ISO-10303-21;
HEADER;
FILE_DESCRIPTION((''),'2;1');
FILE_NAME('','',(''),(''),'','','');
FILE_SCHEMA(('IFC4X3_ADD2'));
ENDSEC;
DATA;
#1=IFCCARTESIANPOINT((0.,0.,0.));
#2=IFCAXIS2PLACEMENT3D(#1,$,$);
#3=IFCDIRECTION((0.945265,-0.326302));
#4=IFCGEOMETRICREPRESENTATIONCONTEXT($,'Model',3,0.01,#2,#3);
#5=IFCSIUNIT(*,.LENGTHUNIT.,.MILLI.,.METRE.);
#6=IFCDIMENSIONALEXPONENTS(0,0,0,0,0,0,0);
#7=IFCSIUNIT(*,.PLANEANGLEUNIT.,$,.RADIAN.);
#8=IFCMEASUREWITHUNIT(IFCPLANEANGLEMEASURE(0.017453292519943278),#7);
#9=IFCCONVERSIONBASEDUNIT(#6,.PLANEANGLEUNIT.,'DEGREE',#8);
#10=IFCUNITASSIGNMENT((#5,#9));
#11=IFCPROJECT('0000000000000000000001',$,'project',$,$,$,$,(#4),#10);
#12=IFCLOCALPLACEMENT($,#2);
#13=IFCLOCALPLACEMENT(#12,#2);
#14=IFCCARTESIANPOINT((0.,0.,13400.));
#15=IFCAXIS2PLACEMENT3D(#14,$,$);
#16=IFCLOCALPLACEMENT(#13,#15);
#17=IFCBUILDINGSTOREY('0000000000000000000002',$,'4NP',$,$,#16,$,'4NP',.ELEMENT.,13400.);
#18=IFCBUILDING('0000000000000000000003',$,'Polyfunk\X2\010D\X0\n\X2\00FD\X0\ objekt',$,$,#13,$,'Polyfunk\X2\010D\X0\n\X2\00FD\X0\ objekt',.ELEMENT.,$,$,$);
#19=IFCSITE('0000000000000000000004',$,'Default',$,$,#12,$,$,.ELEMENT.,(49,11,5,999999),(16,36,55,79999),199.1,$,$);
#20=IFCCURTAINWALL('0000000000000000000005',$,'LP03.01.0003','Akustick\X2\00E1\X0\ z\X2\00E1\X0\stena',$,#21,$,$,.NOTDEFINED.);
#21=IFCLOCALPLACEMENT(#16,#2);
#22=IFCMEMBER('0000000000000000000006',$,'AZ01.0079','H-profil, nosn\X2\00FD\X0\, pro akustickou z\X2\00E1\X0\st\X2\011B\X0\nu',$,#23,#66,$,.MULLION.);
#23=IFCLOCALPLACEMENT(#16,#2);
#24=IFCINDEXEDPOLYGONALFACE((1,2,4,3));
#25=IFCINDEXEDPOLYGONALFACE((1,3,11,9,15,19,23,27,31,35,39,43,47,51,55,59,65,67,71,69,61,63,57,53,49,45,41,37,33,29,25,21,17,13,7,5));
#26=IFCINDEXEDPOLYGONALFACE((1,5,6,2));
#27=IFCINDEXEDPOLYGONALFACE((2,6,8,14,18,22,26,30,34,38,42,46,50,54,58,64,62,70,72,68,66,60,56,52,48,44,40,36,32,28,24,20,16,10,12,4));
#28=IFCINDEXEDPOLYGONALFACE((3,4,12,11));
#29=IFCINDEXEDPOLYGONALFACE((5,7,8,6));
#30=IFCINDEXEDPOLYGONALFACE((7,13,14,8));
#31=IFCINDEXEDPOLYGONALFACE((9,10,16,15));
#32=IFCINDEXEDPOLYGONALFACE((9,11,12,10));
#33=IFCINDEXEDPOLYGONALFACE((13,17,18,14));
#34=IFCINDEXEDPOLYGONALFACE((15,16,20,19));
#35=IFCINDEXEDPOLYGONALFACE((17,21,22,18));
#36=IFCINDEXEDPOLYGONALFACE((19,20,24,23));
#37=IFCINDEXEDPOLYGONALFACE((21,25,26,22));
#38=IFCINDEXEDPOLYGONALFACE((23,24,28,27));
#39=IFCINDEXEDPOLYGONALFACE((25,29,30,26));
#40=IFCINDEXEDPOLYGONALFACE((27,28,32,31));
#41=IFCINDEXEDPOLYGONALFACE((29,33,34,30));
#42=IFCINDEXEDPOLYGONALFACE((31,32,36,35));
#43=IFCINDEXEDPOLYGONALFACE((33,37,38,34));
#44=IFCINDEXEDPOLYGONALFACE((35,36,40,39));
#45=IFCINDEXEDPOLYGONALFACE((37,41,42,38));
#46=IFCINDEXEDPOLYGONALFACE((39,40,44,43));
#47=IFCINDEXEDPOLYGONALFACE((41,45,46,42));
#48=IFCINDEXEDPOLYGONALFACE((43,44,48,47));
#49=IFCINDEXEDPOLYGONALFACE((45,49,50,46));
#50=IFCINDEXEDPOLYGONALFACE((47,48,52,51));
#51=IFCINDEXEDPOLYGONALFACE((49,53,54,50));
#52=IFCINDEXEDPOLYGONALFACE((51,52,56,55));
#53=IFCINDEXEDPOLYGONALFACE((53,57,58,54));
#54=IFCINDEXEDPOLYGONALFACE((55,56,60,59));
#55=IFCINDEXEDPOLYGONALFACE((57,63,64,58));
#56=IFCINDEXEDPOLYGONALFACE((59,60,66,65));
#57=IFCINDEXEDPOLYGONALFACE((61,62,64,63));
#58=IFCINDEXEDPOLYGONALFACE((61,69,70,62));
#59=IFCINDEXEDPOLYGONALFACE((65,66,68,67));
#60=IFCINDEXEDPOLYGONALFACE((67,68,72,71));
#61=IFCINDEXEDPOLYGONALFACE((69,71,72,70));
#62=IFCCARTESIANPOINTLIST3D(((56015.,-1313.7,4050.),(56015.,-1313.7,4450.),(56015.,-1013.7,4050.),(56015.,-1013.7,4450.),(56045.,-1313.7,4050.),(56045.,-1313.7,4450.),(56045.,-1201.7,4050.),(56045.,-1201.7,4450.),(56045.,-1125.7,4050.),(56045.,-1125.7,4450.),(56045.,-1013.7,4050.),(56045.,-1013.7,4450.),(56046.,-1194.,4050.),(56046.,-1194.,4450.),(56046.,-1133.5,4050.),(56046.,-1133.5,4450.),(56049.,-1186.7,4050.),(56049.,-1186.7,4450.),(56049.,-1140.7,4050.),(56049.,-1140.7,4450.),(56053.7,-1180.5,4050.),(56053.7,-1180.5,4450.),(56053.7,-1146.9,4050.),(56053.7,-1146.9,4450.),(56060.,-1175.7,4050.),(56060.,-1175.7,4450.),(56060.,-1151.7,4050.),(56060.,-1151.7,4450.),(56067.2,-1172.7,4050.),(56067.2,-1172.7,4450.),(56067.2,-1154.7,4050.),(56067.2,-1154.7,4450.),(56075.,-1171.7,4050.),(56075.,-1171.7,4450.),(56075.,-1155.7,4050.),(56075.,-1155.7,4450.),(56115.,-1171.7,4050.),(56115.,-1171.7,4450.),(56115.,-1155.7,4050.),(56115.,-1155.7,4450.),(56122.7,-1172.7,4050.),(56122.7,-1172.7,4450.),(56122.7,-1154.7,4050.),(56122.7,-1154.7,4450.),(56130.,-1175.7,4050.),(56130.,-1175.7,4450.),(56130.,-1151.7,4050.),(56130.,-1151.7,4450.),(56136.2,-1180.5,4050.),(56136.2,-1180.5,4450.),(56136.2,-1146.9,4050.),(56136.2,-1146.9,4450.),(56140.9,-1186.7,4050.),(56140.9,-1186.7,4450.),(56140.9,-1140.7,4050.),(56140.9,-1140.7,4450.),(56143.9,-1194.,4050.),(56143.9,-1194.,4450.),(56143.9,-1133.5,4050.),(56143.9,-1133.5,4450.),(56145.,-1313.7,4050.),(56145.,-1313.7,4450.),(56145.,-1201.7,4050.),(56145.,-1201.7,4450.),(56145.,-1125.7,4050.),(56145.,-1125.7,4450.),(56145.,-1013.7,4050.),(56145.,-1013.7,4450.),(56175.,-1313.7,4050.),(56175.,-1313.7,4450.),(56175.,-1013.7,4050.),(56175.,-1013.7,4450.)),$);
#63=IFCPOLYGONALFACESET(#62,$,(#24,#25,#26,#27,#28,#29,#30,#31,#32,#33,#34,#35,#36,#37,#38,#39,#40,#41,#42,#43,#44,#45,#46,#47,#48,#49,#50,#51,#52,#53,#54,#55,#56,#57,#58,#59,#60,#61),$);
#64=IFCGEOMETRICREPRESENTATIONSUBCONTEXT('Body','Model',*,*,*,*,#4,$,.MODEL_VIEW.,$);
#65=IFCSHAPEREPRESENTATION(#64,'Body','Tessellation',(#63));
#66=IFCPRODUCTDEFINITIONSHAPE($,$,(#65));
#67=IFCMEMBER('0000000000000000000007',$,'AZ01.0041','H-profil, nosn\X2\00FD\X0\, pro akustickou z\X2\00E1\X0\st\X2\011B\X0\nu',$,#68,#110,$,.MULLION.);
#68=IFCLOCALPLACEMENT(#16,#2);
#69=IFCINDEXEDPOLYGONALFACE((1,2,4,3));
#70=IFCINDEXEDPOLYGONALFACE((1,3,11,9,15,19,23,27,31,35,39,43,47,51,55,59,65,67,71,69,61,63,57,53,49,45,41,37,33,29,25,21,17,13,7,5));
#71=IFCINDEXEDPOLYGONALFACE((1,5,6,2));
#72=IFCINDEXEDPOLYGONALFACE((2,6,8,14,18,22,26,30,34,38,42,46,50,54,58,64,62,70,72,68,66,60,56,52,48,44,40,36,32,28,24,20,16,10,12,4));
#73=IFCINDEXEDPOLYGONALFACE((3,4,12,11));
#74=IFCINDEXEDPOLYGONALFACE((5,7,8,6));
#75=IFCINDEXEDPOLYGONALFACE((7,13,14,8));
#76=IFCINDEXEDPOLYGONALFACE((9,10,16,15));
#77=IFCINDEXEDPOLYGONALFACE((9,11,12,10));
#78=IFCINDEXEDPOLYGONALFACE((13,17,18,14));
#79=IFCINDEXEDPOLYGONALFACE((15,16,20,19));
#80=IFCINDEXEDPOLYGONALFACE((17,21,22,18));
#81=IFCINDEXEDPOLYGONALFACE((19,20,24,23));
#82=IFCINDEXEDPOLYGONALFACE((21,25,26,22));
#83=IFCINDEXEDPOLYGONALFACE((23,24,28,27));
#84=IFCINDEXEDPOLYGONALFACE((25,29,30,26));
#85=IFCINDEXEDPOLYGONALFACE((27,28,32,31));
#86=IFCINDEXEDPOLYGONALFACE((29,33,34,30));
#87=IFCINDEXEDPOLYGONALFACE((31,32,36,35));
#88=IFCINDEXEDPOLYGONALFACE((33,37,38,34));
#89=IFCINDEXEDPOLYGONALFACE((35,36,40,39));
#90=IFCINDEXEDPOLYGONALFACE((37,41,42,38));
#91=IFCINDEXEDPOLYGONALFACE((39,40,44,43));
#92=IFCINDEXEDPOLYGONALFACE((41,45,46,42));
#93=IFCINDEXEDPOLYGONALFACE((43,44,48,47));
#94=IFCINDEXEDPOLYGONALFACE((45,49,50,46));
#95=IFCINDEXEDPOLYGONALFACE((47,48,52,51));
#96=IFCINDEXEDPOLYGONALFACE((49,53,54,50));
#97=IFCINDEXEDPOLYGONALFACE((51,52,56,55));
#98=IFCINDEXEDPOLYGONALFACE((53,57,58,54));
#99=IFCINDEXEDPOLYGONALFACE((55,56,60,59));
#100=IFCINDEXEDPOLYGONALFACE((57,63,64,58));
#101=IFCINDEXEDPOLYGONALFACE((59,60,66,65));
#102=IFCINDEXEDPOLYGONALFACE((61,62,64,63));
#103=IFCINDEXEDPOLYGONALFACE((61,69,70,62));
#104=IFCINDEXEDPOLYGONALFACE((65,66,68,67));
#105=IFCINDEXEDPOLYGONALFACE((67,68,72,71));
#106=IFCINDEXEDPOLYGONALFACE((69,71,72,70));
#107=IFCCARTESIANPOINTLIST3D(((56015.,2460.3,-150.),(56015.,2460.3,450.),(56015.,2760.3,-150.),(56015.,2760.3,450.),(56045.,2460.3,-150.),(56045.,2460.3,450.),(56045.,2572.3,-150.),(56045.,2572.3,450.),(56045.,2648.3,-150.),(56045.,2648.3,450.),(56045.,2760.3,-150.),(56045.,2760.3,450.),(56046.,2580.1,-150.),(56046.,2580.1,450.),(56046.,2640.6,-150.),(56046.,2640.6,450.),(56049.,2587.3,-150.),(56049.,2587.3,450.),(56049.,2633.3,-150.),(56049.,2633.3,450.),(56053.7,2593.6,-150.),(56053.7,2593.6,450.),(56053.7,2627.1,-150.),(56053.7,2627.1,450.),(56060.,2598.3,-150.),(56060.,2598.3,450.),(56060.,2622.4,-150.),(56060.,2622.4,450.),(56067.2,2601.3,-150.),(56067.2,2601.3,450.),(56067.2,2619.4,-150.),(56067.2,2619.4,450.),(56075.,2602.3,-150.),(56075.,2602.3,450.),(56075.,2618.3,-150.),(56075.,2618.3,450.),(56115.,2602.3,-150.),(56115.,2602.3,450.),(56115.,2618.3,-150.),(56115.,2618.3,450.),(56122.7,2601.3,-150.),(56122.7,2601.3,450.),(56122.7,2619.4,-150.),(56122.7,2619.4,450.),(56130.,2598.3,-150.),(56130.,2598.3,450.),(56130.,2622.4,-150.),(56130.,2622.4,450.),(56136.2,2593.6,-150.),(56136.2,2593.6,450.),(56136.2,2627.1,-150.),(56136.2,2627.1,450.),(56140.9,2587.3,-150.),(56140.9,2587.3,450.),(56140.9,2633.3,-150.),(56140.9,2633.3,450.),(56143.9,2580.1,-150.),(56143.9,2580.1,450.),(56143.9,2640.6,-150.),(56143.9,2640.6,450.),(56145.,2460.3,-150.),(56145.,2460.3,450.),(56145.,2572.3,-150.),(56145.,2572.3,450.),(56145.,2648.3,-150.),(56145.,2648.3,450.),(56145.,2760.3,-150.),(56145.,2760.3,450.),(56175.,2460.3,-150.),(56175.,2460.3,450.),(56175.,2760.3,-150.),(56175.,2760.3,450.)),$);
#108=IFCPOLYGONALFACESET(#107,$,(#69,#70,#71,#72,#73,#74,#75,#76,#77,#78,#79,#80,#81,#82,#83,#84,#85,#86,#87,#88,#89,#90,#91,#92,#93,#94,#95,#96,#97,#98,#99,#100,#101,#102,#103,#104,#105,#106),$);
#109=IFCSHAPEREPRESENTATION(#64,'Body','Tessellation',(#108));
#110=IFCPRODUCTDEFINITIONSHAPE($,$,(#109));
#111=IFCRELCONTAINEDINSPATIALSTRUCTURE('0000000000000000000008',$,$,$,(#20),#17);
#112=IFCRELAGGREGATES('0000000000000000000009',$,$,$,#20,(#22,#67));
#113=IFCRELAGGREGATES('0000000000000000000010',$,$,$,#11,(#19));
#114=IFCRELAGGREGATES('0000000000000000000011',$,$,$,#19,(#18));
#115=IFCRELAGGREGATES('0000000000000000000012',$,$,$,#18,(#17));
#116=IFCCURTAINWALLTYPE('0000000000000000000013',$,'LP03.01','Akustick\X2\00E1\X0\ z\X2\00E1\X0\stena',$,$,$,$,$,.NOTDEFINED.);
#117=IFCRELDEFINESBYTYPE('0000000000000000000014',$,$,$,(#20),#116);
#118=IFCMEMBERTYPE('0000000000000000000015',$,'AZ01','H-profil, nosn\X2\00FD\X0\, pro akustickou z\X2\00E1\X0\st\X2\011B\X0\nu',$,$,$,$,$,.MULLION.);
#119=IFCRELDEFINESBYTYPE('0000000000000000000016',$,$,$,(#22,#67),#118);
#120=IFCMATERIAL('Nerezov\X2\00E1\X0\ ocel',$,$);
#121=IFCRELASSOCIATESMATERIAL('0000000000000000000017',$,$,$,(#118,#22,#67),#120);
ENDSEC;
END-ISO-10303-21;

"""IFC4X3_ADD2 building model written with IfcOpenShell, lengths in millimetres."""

from ifc_helpers import new_model, entity, si_unit, converted_unit, direction, frame, frame_2d, origin, place, context, subcontext, project, spatial, polyline, circle_curve, parameter, trimmed, segment, composite_curve, outline, extrude, source, transform, mapped, material, material_profile, profile_set, profile_usage, type_object, element, aggregate, save


model = new_model("IFC4X3_ADD2")

# Units and contexts
model_context = context("Model", 3, precision=0.01, world=origin(), true_north=direction((0.945265, -0.326302)))
body_context = subcontext(model_context, "Body", "Model", "MODEL_VIEW")
ifc_project = project(units=[si_unit("LENGTHUNIT", "METRE", prefix="MILLI"), converted_unit("PLANEANGLEUNIT", "DEGREE", entity("IfcPlaneAngleMeasure", 0.017453292519943278), si_unit("PLANEANGLEUNIT", "RADIAN"), dimensions=[0, 0, 0, 0, 0, 0, 0])], contexts=[model_context])

# Site, building, storey
site_placement = place(None, origin())
site = spatial("IfcSite", under=ifc_project, at=site_placement, Name="Default", CompositionType="ELEMENT", RefLatitude=(49, 11, 5, 999999), RefLongitude=(16, 36, 55, 79999), RefElevation=199.1)
building_placement = place(site_placement, origin())
building = spatial("IfcBuilding", under=site, at=building_placement, Name="Polyfunkčný objekt", LongName="Polyfunkčný objekt", CompositionType="ELEMENT")
storey_placement = place(building_placement, frame((0.0, 0.0, 13400.0)))
storey = spatial("IfcBuildingStorey", under=building, at=storey_placement, Name="4NP", LongName="4NP", CompositionType="ELEMENT", Elevation=13400.0)

# Curtain wall, members
curtain_wall_type = type_object("IfcCurtainWallType", Name="LP03.01", Description="Akustická zástena", PredefinedType="NOTDEFINED")
curtain_wall_placement = place(storey_placement, frame((0.0, 0.0, -13400.0)))
curtain_wall = element("IfcCurtainWall", 1, at=curtain_wall_placement, inside=storey, type_object=curtain_wall_type, Name="LP03.01.0003", Description="Akustická zástena", PredefinedType="NOTDEFINED")
ifc_material_1 = material(Name="Nerezová ocel")
ifc_material_profile = material_profile(ifc_material_1, outline(composite_curve([segment(polyline([(50.0, -150.0), (80.0, -150.0)]), True, "CONTINUOUS"), segment(polyline([(80.0, -150.0), (80.0, 150.0)]), True, "CONTINUOUS"), segment(polyline([(80.0, 150.0), (50.0, 150.0)]), True, "CONTINUOUS"), segment(polyline([(50.0, 150.0), (50.0, 38.0)]), True, "CONTINUOUS"), segment(trimmed(circle_curve(frame_2d((20.0, 38.0), x_axis=(0.0, 1.0)), 30.0), [parameter(180.0)], [parameter(270.0)], True, "PARAMETER"), False, "CONTINUOUS"), segment(polyline([(20.0, 8.0), (-20.0, 8.0)]), True, "CONTINUOUS"), segment(trimmed(circle_curve(frame_2d((-20.0, 38.0), x_axis=(0.0, 1.0)), 30.0), [parameter(90.0)], [parameter(180.0)], True, "PARAMETER"), False, "CONTINUOUS"), segment(polyline([(-50.0, 38.0), (-50.0, 150.0)]), True, "CONTINUOUS"), segment(polyline([(-50.0, 150.0), (-80.0, 150.0)]), True, "CONTINUOUS"), segment(polyline([(-80.0, 150.0), (-80.0, -150.0)]), True, "CONTINUOUS"), segment(polyline([(-80.0, -150.0), (-50.0, -150.0)]), True, "CONTINUOUS"), segment(polyline([(-50.0, -150.0), (-50.0, -38.0)]), True, "CONTINUOUS"), segment(trimmed(circle_curve(frame_2d((-20.0, -38.0), x_axis=(0.0, 1.0)), 30.0), [parameter(0.0)], [parameter(90.0)], True, "PARAMETER"), False, "CONTINUOUS"), segment(polyline([(-20.0, -8.0), (20.0, -8.0)]), True, "CONTINUOUS"), segment(trimmed(circle_curve(frame_2d((20.0, -38.0), x_axis=(0.0, 1.0)), 30.0), [parameter(270.0)], [parameter(0.0)], True, "PARAMETER"), False, "CONTINUOUS"), segment(polyline([(50.0, -38.0), (50.0, -150.0)]), True, "CONTINUOUS")], self_intersect=False)), Name="Profil zástena")
ifc_profile_set = profile_set([ifc_material_profile], Name="Profil zástena")
ifc_profile_usage = profile_usage(ifc_profile_set)
member_type = type_object("IfcMemberType", Name="AZ01", Description="H-profil, nosný, pro akustickou zástěnu", PredefinedType="MULLION", material=ifc_profile_set)
shared_shape_1 = source(origin(), body_context, "Body", "SweptSolid", [
    extrude(outline(composite_curve([segment(polyline([(50.0, -150.0), (80.0, -150.0)]), True, "CONTINUOUS"), segment(polyline([(80.0, -150.0), (80.0, 150.0)]), True, "CONTINUOUS"), segment(polyline([(80.0, 150.0), (50.0, 150.0)]), True, "CONTINUOUS"), segment(polyline([(50.0, 150.0), (50.0, 38.0)]), True, "CONTINUOUS"), segment(trimmed(circle_curve(frame_2d((20.0, 38.0), x_axis=(0.0, 1.0)), 30.0), [parameter(180.0)], [parameter(270.0)], True, "PARAMETER"), False, "CONTINUOUS"), segment(polyline([(20.0, 8.0), (-20.0, 8.0)]), True, "CONTINUOUS"), segment(trimmed(circle_curve(frame_2d((-20.0, 38.0), x_axis=(0.0, 1.0)), 30.0), [parameter(90.0)], [parameter(180.0)], True, "PARAMETER"), False, "CONTINUOUS"), segment(polyline([(-50.0, 38.0), (-50.0, 150.0)]), True, "CONTINUOUS"), segment(polyline([(-50.0, 150.0), (-80.0, 150.0)]), True, "CONTINUOUS"), segment(polyline([(-80.0, 150.0), (-80.0, -150.0)]), True, "CONTINUOUS"), segment(polyline([(-80.0, -150.0), (-50.0, -150.0)]), True, "CONTINUOUS"), segment(polyline([(-50.0, -150.0), (-50.0, -38.0)]), True, "CONTINUOUS"), segment(trimmed(circle_curve(frame_2d((-20.0, -38.0), x_axis=(0.0, 1.0)), 30.0), [parameter(0.0)], [parameter(90.0)], True, "PARAMETER"), False, "CONTINUOUS"), segment(polyline([(-20.0, -8.0), (20.0, -8.0)]), True, "CONTINUOUS"), segment(trimmed(circle_curve(frame_2d((20.0, -38.0), x_axis=(0.0, 1.0)), 30.0), [parameter(270.0)], [parameter(0.0)], True, "PARAMETER"), False, "CONTINUOUS"), segment(polyline([(50.0, -38.0), (50.0, -150.0)]), True, "CONTINUOUS")], self_intersect=False)), frame((-150.0, 0.0, -400.0), z_axis=(0.0, 0.0, 1.0), x_axis=(0.0, 1.0, 0.0)), (0.0, 0.0, 1.0), 400.0),
])
member_1_placement = place(curtain_wall_placement, frame((56095.0, -1313.7, 17850.0), z_axis=(0.0, 0.0, 1.0), x_axis=(0.0, -1.0, 0.0)))
member_1 = element("IfcMember", 2, at=member_1_placement, type_object=member_type, material=ifc_profile_usage, Name="AZ01.0079", Description="H-profil, nosný, pro akustickou zástěnu", PredefinedType="MULLION", context=body_context, shape_type="MappedRepresentation", body=[
    mapped(shared_shape_1, transform((0.0, 0.0, 0.0), scale=1.0)),
])
shared_shape_2 = source(origin(), body_context, "Body", "SweptSolid", [
    extrude(outline(composite_curve([segment(polyline([(-150.0, -50.0), (-150.0, -80.0)]), True, "CONTINUOUS"), segment(polyline([(-150.0, -80.0), (150.0, -80.0)]), True, "CONTINUOUS"), segment(polyline([(150.0, -80.0), (150.0, -50.0)]), True, "CONTINUOUS"), segment(polyline([(150.0, -50.0), (38.0, -50.0)]), True, "CONTINUOUS"), segment(trimmed(circle_curve(frame_2d((38.0, -20.0), x_axis=(1.0, 0.0)), 30.0), [parameter(180.0)], [parameter(270.0)], True, "PARAMETER"), False, "CONTINUOUS"), segment(polyline([(8.0, -20.0), (8.0, 20.0)]), True, "CONTINUOUS"), segment(trimmed(circle_curve(frame_2d((38.0, 20.0), x_axis=(1.0, 0.0)), 30.0), [parameter(90.0)], [parameter(180.0)], True, "PARAMETER"), False, "CONTINUOUS"), segment(polyline([(38.0, 50.0), (150.0, 50.0)]), True, "CONTINUOUS"), segment(polyline([(150.0, 50.0), (150.0, 80.0)]), True, "CONTINUOUS"), segment(polyline([(150.0, 80.0), (-150.0, 80.0)]), True, "CONTINUOUS"), segment(polyline([(-150.0, 80.0), (-150.0, 50.0)]), True, "CONTINUOUS"), segment(polyline([(-150.0, 50.0), (-38.0, 50.0)]), True, "CONTINUOUS"), segment(trimmed(circle_curve(frame_2d((-38.0, 20.0), x_axis=(1.0, 0.0)), 30.0), [parameter(0.0)], [parameter(90.0)], True, "PARAMETER"), False, "CONTINUOUS"), segment(polyline([(-8.0, 20.0), (-8.0, -20.0)]), True, "CONTINUOUS"), segment(trimmed(circle_curve(frame_2d((-38.0, -20.0), x_axis=(1.0, 0.0)), 30.0), [parameter(270.0)], [parameter(0.0)], True, "PARAMETER"), False, "CONTINUOUS"), segment(polyline([(-38.0, -50.0), (-150.0, -50.0)]), True, "CONTINUOUS")], self_intersect=False)), frame((0.0, 0.0, -600.0), z_axis=(0.0, 0.0, -1.0), x_axis=(1.0, 0.0, 0.0)), (0.0, 0.0, -1.0), 600.0),
])
member_2_placement = place(curtain_wall_placement, frame((56095.0, 2610.3, 13250.0), z_axis=(0.0, 0.0, -1.0), x_axis=(0.0, 1.0, 0.0)))
member_2 = element("IfcMember", 3, at=member_2_placement, type_object=member_type, material=ifc_profile_usage, Name="AZ01.0041", Description="H-profil, nosný, pro akustickou zástěnu", PredefinedType="MULLION", context=body_context, shape_type="MappedRepresentation", body=[
    mapped(shared_shape_2, transform((0.0, 0.0, 0.0), scale=1.0)),
])
aggregate(curtain_wall, [member_1, member_2])

save(model, "model.ifc")
